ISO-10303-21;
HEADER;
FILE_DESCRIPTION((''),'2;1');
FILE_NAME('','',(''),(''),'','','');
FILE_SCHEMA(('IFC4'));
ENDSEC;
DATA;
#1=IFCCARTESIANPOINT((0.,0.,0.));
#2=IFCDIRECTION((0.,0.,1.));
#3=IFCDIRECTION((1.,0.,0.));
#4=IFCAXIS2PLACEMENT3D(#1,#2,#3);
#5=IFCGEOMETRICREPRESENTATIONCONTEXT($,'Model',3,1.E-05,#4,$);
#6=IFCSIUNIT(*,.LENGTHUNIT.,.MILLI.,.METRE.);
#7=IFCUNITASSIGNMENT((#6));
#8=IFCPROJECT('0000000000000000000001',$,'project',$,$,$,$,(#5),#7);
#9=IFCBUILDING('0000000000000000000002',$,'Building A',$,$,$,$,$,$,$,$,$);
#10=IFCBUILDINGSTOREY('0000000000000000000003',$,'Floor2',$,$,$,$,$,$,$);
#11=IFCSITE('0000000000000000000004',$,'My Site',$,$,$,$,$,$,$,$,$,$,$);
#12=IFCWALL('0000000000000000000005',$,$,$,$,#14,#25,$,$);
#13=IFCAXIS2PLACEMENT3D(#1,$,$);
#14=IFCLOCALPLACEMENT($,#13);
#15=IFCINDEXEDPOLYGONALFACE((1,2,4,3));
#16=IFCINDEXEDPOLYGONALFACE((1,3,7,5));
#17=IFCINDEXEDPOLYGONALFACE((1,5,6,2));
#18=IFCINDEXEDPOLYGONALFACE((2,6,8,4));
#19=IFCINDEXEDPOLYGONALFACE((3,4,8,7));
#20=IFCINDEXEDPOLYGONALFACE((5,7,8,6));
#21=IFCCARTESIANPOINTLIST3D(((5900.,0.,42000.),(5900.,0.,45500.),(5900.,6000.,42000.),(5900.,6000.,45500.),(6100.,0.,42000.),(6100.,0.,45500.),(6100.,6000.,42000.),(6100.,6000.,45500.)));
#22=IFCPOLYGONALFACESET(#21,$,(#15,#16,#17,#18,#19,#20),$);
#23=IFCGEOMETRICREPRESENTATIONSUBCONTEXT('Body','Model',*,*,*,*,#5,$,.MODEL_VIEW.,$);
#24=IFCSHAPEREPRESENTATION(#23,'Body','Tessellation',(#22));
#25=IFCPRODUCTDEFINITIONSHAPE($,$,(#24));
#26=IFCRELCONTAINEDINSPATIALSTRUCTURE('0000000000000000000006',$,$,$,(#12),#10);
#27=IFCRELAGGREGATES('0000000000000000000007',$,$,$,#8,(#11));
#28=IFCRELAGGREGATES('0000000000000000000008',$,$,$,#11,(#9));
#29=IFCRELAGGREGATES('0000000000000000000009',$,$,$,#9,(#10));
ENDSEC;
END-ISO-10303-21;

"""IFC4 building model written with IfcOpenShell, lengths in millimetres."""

from ifc_helpers import new_model, si_unit, frame, origin_with_axes, place, context, subcontext, project, spatial, indexed_curve, outline, extrude, element, save


model = new_model("IFC4")

# Units and contexts
model_context = context("Model", 3, precision=1e-05, world=origin_with_axes())
body_context = subcontext(model_context, "Body", "Model", "MODEL_VIEW")
ifc_project = project(units=[si_unit("LENGTHUNIT", "METRE", prefix="MILLI")], contexts=[model_context])

# Site, building, storey
site = spatial("IfcSite", under=ifc_project, Name="My Site")
building = spatial("IfcBuilding", under=site, Name="Building A")
storey = spatial("IfcBuildingStorey", under=building, Name="Floor2")

# Wall
wall_placement = place(None, frame((6100.0, 0.0, 42000.0), z_axis=(0.0, 0.0, 1.0), x_axis=(0.0, 1.0, 0.0)))
element("IfcWall", 1, at=wall_placement, inside=storey, context=body_context, shape_type="SweptSolid", body=[
    extrude(outline(indexed_curve([(0.0, 0.0), (0.0, 200.0), (6000.0, 200.0), (6000.0, 0.0), (0.0, 0.0)], self_intersect=False)), origin_with_axes(), (0.0, 0.0, 1.0), 3500.0),
])

save(model, "model.ifc")
